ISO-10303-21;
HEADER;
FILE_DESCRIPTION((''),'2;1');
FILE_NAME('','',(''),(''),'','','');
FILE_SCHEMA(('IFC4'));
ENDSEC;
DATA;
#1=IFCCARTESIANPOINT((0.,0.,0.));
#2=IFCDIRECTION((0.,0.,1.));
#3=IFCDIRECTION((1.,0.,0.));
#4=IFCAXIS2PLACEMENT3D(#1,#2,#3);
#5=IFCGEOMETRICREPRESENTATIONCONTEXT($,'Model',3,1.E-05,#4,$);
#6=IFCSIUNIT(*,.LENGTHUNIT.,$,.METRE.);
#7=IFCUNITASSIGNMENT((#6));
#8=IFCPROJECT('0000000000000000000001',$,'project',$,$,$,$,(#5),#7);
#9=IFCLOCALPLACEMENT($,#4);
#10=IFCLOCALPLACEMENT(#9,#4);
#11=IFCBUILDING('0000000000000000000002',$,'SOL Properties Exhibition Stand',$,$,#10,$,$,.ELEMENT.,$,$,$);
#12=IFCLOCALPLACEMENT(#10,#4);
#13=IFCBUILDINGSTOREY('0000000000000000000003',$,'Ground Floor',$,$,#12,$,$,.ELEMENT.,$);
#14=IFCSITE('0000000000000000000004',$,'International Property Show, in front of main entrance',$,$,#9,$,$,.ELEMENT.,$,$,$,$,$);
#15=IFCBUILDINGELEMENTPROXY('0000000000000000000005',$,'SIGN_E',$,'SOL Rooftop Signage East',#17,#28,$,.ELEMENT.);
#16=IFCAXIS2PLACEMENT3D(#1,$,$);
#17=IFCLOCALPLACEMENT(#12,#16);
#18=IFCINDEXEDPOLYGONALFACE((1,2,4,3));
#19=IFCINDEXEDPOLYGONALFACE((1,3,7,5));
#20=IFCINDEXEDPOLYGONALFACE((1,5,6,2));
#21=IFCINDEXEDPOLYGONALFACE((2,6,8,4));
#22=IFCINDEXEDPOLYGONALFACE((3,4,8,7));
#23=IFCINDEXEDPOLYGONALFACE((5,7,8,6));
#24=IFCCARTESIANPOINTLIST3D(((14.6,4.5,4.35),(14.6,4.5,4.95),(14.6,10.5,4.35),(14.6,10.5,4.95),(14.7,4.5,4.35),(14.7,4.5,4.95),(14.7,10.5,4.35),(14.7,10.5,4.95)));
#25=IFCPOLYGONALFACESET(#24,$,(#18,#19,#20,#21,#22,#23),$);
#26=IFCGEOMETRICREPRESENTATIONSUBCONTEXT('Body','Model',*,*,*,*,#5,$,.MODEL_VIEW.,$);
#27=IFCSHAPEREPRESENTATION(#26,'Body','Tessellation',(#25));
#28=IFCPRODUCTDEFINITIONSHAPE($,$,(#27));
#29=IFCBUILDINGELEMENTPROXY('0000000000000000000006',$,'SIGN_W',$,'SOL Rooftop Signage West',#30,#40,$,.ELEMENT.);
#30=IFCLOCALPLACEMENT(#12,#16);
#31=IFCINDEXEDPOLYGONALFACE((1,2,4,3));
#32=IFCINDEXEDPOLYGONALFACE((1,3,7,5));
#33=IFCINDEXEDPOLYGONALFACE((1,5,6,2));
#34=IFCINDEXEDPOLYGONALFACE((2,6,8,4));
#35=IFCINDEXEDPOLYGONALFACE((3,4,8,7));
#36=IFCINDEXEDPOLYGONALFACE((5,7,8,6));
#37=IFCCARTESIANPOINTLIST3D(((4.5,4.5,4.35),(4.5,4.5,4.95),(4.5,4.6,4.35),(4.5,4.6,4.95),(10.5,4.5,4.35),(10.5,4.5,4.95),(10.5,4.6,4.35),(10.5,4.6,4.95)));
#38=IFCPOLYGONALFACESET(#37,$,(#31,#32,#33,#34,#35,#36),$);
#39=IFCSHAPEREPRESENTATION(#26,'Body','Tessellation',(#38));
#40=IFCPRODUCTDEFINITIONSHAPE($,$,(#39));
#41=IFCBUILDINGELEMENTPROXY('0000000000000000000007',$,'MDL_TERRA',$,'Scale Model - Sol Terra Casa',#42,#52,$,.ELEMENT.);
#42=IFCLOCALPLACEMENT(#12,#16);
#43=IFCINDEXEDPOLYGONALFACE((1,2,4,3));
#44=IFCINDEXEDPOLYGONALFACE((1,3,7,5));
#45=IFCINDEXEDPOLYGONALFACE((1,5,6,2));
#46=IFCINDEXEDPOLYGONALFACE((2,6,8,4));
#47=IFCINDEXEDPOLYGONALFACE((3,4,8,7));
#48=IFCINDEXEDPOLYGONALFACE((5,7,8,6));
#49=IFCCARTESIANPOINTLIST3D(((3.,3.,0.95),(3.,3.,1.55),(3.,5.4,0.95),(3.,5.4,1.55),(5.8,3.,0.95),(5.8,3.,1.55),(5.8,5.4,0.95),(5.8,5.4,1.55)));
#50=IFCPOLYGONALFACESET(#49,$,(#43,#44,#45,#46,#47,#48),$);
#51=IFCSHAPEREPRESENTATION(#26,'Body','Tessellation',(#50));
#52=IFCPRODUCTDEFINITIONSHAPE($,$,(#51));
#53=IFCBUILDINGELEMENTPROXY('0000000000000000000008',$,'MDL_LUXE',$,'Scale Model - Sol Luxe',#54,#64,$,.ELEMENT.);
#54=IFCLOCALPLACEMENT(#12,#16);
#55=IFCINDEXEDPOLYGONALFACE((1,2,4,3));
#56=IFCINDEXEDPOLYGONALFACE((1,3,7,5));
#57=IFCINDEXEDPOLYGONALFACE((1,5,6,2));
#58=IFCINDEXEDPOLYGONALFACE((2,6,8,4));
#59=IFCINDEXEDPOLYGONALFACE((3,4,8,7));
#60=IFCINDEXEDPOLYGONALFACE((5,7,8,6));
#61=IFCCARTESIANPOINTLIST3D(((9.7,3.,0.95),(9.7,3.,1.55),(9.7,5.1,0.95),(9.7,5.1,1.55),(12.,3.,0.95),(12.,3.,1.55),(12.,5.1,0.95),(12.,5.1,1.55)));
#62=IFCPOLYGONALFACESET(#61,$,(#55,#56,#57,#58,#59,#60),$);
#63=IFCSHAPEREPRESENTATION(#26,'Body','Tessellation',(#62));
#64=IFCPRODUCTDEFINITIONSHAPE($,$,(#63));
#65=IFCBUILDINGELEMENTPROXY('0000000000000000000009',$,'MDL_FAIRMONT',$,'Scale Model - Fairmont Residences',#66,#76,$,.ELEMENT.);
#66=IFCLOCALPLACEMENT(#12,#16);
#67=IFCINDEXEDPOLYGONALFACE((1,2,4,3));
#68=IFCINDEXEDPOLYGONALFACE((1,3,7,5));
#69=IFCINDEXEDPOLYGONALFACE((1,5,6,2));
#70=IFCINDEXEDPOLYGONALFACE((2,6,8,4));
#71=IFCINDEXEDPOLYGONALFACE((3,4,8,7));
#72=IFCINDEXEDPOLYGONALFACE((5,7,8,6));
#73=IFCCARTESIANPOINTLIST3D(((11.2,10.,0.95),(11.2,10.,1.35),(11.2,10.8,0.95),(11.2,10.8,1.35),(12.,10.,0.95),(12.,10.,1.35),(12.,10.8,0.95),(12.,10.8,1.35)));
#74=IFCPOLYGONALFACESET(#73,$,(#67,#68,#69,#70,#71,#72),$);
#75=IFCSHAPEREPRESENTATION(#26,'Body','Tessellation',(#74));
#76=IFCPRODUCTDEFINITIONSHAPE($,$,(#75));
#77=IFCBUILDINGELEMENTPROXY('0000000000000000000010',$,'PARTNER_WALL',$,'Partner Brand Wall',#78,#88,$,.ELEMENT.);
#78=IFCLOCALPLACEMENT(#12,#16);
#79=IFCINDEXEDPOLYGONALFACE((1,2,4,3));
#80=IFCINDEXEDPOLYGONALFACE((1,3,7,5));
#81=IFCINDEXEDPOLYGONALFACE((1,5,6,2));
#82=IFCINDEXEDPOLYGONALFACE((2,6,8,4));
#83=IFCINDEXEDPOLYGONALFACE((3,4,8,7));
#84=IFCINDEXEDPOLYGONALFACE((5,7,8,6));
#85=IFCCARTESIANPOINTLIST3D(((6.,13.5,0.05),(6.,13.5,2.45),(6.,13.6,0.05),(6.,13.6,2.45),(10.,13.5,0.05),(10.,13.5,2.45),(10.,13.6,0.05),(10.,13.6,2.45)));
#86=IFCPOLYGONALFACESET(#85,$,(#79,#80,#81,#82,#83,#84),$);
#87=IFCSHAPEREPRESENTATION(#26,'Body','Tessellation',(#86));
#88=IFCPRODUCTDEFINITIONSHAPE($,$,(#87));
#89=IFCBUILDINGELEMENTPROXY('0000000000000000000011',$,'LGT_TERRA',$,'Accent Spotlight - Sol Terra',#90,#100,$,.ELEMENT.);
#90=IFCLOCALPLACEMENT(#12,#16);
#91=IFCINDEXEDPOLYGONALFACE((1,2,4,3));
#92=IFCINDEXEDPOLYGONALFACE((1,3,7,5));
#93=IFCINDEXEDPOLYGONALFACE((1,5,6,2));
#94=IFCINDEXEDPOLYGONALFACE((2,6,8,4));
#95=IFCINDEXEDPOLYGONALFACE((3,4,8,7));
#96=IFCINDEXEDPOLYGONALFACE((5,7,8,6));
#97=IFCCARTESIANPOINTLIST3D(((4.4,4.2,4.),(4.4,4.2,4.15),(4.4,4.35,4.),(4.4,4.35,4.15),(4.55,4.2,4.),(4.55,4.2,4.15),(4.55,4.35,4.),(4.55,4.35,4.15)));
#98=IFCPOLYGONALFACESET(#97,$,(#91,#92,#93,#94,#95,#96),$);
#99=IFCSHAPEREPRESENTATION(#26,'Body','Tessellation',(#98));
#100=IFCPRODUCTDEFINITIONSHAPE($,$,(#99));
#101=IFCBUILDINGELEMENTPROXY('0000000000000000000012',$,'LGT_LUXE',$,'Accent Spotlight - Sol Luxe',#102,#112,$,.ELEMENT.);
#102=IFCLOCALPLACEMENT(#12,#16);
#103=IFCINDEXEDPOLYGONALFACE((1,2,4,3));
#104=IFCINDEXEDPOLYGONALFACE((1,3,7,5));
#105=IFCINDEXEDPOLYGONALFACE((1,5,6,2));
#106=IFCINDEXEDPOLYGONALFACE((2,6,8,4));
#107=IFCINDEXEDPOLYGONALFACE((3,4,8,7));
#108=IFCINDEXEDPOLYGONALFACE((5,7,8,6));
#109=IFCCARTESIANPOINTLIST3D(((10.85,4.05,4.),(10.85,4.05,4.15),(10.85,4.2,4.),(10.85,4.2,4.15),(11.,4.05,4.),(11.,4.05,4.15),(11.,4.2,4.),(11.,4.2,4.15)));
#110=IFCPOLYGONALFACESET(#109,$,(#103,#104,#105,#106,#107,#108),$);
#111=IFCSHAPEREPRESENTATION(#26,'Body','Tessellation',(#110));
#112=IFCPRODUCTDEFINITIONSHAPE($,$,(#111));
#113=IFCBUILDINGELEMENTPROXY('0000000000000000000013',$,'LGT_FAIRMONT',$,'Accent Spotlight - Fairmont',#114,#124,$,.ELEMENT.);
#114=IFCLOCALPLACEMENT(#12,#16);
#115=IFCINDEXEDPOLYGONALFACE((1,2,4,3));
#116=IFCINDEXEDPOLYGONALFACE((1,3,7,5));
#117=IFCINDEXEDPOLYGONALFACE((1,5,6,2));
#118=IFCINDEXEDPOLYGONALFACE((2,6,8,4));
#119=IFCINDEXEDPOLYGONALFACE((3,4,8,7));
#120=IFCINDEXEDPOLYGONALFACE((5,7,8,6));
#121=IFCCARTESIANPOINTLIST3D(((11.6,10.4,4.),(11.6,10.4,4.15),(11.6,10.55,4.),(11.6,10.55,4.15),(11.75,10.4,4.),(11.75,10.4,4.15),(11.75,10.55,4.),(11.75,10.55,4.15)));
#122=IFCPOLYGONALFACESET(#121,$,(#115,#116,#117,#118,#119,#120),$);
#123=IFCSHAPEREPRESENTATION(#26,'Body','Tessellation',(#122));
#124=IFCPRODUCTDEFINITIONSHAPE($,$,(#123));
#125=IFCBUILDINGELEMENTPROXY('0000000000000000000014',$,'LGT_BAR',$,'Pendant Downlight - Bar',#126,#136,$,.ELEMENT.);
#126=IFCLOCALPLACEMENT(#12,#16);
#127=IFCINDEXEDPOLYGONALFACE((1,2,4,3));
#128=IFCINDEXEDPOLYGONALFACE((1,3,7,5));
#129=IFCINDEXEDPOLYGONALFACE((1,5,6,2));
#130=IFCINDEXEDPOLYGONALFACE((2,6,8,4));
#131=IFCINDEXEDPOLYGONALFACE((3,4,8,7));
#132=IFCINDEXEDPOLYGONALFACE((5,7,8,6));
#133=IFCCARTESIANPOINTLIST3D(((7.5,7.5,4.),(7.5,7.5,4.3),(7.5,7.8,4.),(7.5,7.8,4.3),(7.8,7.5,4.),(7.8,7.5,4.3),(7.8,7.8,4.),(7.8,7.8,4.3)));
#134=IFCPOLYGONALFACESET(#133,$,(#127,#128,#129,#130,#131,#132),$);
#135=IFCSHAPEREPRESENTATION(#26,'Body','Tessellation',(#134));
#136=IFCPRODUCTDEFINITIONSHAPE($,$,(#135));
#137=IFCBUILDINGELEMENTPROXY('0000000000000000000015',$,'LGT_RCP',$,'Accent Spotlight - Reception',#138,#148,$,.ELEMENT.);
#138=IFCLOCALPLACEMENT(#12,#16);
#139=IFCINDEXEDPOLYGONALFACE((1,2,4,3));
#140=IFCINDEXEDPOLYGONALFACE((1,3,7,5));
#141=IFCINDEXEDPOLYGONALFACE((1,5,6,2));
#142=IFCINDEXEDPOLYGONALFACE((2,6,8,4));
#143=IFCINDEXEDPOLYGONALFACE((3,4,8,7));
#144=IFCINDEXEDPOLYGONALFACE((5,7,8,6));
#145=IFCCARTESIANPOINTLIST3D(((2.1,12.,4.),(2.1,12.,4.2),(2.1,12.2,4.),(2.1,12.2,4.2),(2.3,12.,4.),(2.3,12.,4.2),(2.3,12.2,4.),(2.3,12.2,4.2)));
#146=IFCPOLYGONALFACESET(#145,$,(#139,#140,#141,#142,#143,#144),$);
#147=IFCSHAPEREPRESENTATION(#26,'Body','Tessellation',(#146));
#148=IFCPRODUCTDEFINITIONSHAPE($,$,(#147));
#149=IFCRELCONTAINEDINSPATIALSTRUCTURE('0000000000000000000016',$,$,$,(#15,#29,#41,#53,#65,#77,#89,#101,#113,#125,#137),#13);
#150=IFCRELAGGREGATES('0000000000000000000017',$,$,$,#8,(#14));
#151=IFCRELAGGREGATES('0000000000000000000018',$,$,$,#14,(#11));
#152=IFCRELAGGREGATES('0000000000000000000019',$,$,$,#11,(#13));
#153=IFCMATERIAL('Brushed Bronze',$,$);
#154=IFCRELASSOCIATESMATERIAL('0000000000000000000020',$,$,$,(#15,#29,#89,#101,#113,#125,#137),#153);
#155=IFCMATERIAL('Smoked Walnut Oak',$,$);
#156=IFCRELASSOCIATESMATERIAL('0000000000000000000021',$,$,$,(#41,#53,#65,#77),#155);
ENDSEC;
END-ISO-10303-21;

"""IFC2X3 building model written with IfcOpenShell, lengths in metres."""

from ifc_helpers import new_model, si_unit, frame, frame_2d, origin, origin_with_axes, place, context, subcontext, project, spatial, rectangle, extrude, material, element, save


model = new_model("IFC2X3")

# Units and contexts
model_context = context("Model", 3, precision=1e-05, world=origin_with_axes())
body_context = subcontext(model_context, "Body", "Model", "MODEL_VIEW")
ifc_project = project(units=[si_unit("LENGTHUNIT", "METRE")], contexts=[model_context])

# Site, building, storey
site_placement = place(None, origin_with_axes())
site = spatial("IfcSite", under=ifc_project, at=site_placement, Name="International Property Show, in front of main entrance", CompositionType="ELEMENT")
building_placement = place(site_placement, origin_with_axes())
building = spatial("IfcBuilding", under=site, at=building_placement, Name="SOL Properties Exhibition Stand", CompositionType="ELEMENT")
storey_placement = place(building_placement, origin_with_axes())
storey = spatial("IfcBuildingStorey", under=building, at=storey_placement, Name="Ground Floor", CompositionType="ELEMENT")

# Shared definitions
ifc_material_1 = material(Name="Smoked Walnut Oak")

# Shared definitions
ifc_material_2 = material(Name="Brushed Bronze")

# Building element proxies
proxy_1_placement = place(storey_placement, frame((14.6, 4.5, 4.35), z_axis=(0.0, 0.0, 1.0), x_axis=(1.0, 0.0, 0.0)))
element("IfcBuildingElementProxy", 1, at=proxy_1_placement, inside=storey, material=ifc_material_2, Name="SIGN_E", ObjectType="SOL Rooftop Signage East", CompositionType="ELEMENT", context=body_context, shape_type="SweptSolid", body=[
    extrude(rectangle(XDim=0.1, YDim=6.0, at=frame_2d((0.05, 3.0))), origin(), (0.0, 0.0, 1.0), 0.6),
])
proxy_2_placement = place(storey_placement, frame((4.5, 4.5, 4.35), z_axis=(0.0, 0.0, 1.0), x_axis=(1.0, 0.0, 0.0)))
element("IfcBuildingElementProxy", 2, at=proxy_2_placement, inside=storey, material=ifc_material_2, Name="SIGN_W", ObjectType="SOL Rooftop Signage West", CompositionType="ELEMENT", context=body_context, shape_type="SweptSolid", body=[
    extrude(rectangle(XDim=6.0, YDim=0.1, at=frame_2d((3.0, 0.05))), origin(), (0.0, 0.0, 1.0), 0.6),
])
proxy_3_placement = place(storey_placement, frame((3.0, 3.0, 0.95), z_axis=(0.0, 0.0, 1.0), x_axis=(1.0, 0.0, 0.0)))
element("IfcBuildingElementProxy", 3, at=proxy_3_placement, inside=storey, material=ifc_material_1, Name="MDL_TERRA", ObjectType="Scale Model - Sol Terra Casa", CompositionType="ELEMENT", context=body_context, shape_type="SweptSolid", body=[
    extrude(rectangle(XDim=2.8, YDim=2.4, at=frame_2d((1.4, 1.2))), origin(), (0.0, 0.0, 1.0), 0.6),
])
proxy_4_placement = place(storey_placement, frame((9.7, 3.0, 0.95), z_axis=(0.0, 0.0, 1.0), x_axis=(1.0, 0.0, 0.0)))
element("IfcBuildingElementProxy", 4, at=proxy_4_placement, inside=storey, material=ifc_material_1, Name="MDL_LUXE", ObjectType="Scale Model - Sol Luxe", CompositionType="ELEMENT", context=body_context, shape_type="SweptSolid", body=[
    extrude(rectangle(XDim=2.3, YDim=2.1, at=frame_2d((1.15, 1.05))), origin(), (0.0, 0.0, 1.0), 0.6),
])
proxy_5_placement = place(storey_placement, frame((11.2, 10.0, 0.95), z_axis=(0.0, 0.0, 1.0), x_axis=(1.0, 0.0, 0.0)))
element("IfcBuildingElementProxy", 5, at=proxy_5_placement, inside=storey, material=ifc_material_1, Name="MDL_FAIRMONT", ObjectType="Scale Model - Fairmont Residences", CompositionType="ELEMENT", context=body_context, shape_type="SweptSolid", body=[
    extrude(rectangle(XDim=0.8, YDim=0.8, at=frame_2d((0.4, 0.4))), origin(), (0.0, 0.0, 1.0), 0.4),
])
proxy_6_placement = place(storey_placement, frame((6.0, 13.5, 0.05), z_axis=(0.0, 0.0, 1.0), x_axis=(1.0, 0.0, 0.0)))
element("IfcBuildingElementProxy", 6, at=proxy_6_placement, inside=storey, material=ifc_material_1, Name="PARTNER_WALL", ObjectType="Partner Brand Wall", CompositionType="ELEMENT", context=body_context, shape_type="SweptSolid", body=[
    extrude(rectangle(XDim=4.0, YDim=0.1, at=frame_2d((2.0, 0.05))), origin(), (0.0, 0.0, 1.0), 2.4),
])
proxy_7_placement = place(storey_placement, frame((4.4, 4.2, 4.0), z_axis=(0.0, 0.0, 1.0), x_axis=(1.0, 0.0, 0.0)))
element("IfcBuildingElementProxy", 7, at=proxy_7_placement, inside=storey, material=ifc_material_2, Name="LGT_TERRA", ObjectType="Accent Spotlight - Sol Terra", CompositionType="ELEMENT", context=body_context, shape_type="SweptSolid", body=[
    extrude(rectangle(XDim=0.15, YDim=0.15, at=frame_2d((0.075, 0.075))), origin(), (0.0, 0.0, 1.0), 0.15),
])
proxy_8_placement = place(storey_placement, frame((10.85, 4.05, 4.0), z_axis=(0.0, 0.0, 1.0), x_axis=(1.0, 0.0, 0.0)))
element("IfcBuildingElementProxy", 8, at=proxy_8_placement, inside=storey, material=ifc_material_2, Name="LGT_LUXE", ObjectType="Accent Spotlight - Sol Luxe", CompositionType="ELEMENT", context=body_context, shape_type="SweptSolid", body=[
    extrude(rectangle(XDim=0.15, YDim=0.15, at=frame_2d((0.075, 0.075))), origin(), (0.0, 0.0, 1.0), 0.15),
])
proxy_9_placement = place(storey_placement, frame((11.6, 10.4, 4.0), z_axis=(0.0, 0.0, 1.0), x_axis=(1.0, 0.0, 0.0)))
element("IfcBuildingElementProxy", 9, at=proxy_9_placement, inside=storey, material=ifc_material_2, Name="LGT_FAIRMONT", ObjectType="Accent Spotlight - Fairmont", CompositionType="ELEMENT", context=body_context, shape_type="SweptSolid", body=[
    extrude(rectangle(XDim=0.15, YDim=0.15, at=frame_2d((0.075, 0.075))), origin(), (0.0, 0.0, 1.0), 0.15),
])
proxy_10_placement = place(storey_placement, frame((7.5, 7.5, 4.0), z_axis=(0.0, 0.0, 1.0), x_axis=(1.0, 0.0, 0.0)))
element("IfcBuildingElementProxy", 10, at=proxy_10_placement, inside=storey, material=ifc_material_2, Name="LGT_BAR", ObjectType="Pendant Downlight - Bar", CompositionType="ELEMENT", context=body_context, shape_type="SweptSolid", body=[
    extrude(rectangle(XDim=0.3, YDim=0.3, at=frame_2d((0.15, 0.15))), origin(), (0.0, 0.0, 1.0), 0.3),
])
proxy_11_placement = place(storey_placement, frame((2.1, 12.0, 4.0), z_axis=(0.0, 0.0, 1.0), x_axis=(1.0, 0.0, 0.0)))
element("IfcBuildingElementProxy", 11, at=proxy_11_placement, inside=storey, material=ifc_material_2, Name="LGT_RCP", ObjectType="Accent Spotlight - Reception", CompositionType="ELEMENT", context=body_context, shape_type="SweptSolid", body=[
    extrude(rectangle(XDim=0.2, YDim=0.2, at=frame_2d((0.1, 0.1))), origin(), (0.0, 0.0, 1.0), 0.2),
])

save(model, "model.ifc")
